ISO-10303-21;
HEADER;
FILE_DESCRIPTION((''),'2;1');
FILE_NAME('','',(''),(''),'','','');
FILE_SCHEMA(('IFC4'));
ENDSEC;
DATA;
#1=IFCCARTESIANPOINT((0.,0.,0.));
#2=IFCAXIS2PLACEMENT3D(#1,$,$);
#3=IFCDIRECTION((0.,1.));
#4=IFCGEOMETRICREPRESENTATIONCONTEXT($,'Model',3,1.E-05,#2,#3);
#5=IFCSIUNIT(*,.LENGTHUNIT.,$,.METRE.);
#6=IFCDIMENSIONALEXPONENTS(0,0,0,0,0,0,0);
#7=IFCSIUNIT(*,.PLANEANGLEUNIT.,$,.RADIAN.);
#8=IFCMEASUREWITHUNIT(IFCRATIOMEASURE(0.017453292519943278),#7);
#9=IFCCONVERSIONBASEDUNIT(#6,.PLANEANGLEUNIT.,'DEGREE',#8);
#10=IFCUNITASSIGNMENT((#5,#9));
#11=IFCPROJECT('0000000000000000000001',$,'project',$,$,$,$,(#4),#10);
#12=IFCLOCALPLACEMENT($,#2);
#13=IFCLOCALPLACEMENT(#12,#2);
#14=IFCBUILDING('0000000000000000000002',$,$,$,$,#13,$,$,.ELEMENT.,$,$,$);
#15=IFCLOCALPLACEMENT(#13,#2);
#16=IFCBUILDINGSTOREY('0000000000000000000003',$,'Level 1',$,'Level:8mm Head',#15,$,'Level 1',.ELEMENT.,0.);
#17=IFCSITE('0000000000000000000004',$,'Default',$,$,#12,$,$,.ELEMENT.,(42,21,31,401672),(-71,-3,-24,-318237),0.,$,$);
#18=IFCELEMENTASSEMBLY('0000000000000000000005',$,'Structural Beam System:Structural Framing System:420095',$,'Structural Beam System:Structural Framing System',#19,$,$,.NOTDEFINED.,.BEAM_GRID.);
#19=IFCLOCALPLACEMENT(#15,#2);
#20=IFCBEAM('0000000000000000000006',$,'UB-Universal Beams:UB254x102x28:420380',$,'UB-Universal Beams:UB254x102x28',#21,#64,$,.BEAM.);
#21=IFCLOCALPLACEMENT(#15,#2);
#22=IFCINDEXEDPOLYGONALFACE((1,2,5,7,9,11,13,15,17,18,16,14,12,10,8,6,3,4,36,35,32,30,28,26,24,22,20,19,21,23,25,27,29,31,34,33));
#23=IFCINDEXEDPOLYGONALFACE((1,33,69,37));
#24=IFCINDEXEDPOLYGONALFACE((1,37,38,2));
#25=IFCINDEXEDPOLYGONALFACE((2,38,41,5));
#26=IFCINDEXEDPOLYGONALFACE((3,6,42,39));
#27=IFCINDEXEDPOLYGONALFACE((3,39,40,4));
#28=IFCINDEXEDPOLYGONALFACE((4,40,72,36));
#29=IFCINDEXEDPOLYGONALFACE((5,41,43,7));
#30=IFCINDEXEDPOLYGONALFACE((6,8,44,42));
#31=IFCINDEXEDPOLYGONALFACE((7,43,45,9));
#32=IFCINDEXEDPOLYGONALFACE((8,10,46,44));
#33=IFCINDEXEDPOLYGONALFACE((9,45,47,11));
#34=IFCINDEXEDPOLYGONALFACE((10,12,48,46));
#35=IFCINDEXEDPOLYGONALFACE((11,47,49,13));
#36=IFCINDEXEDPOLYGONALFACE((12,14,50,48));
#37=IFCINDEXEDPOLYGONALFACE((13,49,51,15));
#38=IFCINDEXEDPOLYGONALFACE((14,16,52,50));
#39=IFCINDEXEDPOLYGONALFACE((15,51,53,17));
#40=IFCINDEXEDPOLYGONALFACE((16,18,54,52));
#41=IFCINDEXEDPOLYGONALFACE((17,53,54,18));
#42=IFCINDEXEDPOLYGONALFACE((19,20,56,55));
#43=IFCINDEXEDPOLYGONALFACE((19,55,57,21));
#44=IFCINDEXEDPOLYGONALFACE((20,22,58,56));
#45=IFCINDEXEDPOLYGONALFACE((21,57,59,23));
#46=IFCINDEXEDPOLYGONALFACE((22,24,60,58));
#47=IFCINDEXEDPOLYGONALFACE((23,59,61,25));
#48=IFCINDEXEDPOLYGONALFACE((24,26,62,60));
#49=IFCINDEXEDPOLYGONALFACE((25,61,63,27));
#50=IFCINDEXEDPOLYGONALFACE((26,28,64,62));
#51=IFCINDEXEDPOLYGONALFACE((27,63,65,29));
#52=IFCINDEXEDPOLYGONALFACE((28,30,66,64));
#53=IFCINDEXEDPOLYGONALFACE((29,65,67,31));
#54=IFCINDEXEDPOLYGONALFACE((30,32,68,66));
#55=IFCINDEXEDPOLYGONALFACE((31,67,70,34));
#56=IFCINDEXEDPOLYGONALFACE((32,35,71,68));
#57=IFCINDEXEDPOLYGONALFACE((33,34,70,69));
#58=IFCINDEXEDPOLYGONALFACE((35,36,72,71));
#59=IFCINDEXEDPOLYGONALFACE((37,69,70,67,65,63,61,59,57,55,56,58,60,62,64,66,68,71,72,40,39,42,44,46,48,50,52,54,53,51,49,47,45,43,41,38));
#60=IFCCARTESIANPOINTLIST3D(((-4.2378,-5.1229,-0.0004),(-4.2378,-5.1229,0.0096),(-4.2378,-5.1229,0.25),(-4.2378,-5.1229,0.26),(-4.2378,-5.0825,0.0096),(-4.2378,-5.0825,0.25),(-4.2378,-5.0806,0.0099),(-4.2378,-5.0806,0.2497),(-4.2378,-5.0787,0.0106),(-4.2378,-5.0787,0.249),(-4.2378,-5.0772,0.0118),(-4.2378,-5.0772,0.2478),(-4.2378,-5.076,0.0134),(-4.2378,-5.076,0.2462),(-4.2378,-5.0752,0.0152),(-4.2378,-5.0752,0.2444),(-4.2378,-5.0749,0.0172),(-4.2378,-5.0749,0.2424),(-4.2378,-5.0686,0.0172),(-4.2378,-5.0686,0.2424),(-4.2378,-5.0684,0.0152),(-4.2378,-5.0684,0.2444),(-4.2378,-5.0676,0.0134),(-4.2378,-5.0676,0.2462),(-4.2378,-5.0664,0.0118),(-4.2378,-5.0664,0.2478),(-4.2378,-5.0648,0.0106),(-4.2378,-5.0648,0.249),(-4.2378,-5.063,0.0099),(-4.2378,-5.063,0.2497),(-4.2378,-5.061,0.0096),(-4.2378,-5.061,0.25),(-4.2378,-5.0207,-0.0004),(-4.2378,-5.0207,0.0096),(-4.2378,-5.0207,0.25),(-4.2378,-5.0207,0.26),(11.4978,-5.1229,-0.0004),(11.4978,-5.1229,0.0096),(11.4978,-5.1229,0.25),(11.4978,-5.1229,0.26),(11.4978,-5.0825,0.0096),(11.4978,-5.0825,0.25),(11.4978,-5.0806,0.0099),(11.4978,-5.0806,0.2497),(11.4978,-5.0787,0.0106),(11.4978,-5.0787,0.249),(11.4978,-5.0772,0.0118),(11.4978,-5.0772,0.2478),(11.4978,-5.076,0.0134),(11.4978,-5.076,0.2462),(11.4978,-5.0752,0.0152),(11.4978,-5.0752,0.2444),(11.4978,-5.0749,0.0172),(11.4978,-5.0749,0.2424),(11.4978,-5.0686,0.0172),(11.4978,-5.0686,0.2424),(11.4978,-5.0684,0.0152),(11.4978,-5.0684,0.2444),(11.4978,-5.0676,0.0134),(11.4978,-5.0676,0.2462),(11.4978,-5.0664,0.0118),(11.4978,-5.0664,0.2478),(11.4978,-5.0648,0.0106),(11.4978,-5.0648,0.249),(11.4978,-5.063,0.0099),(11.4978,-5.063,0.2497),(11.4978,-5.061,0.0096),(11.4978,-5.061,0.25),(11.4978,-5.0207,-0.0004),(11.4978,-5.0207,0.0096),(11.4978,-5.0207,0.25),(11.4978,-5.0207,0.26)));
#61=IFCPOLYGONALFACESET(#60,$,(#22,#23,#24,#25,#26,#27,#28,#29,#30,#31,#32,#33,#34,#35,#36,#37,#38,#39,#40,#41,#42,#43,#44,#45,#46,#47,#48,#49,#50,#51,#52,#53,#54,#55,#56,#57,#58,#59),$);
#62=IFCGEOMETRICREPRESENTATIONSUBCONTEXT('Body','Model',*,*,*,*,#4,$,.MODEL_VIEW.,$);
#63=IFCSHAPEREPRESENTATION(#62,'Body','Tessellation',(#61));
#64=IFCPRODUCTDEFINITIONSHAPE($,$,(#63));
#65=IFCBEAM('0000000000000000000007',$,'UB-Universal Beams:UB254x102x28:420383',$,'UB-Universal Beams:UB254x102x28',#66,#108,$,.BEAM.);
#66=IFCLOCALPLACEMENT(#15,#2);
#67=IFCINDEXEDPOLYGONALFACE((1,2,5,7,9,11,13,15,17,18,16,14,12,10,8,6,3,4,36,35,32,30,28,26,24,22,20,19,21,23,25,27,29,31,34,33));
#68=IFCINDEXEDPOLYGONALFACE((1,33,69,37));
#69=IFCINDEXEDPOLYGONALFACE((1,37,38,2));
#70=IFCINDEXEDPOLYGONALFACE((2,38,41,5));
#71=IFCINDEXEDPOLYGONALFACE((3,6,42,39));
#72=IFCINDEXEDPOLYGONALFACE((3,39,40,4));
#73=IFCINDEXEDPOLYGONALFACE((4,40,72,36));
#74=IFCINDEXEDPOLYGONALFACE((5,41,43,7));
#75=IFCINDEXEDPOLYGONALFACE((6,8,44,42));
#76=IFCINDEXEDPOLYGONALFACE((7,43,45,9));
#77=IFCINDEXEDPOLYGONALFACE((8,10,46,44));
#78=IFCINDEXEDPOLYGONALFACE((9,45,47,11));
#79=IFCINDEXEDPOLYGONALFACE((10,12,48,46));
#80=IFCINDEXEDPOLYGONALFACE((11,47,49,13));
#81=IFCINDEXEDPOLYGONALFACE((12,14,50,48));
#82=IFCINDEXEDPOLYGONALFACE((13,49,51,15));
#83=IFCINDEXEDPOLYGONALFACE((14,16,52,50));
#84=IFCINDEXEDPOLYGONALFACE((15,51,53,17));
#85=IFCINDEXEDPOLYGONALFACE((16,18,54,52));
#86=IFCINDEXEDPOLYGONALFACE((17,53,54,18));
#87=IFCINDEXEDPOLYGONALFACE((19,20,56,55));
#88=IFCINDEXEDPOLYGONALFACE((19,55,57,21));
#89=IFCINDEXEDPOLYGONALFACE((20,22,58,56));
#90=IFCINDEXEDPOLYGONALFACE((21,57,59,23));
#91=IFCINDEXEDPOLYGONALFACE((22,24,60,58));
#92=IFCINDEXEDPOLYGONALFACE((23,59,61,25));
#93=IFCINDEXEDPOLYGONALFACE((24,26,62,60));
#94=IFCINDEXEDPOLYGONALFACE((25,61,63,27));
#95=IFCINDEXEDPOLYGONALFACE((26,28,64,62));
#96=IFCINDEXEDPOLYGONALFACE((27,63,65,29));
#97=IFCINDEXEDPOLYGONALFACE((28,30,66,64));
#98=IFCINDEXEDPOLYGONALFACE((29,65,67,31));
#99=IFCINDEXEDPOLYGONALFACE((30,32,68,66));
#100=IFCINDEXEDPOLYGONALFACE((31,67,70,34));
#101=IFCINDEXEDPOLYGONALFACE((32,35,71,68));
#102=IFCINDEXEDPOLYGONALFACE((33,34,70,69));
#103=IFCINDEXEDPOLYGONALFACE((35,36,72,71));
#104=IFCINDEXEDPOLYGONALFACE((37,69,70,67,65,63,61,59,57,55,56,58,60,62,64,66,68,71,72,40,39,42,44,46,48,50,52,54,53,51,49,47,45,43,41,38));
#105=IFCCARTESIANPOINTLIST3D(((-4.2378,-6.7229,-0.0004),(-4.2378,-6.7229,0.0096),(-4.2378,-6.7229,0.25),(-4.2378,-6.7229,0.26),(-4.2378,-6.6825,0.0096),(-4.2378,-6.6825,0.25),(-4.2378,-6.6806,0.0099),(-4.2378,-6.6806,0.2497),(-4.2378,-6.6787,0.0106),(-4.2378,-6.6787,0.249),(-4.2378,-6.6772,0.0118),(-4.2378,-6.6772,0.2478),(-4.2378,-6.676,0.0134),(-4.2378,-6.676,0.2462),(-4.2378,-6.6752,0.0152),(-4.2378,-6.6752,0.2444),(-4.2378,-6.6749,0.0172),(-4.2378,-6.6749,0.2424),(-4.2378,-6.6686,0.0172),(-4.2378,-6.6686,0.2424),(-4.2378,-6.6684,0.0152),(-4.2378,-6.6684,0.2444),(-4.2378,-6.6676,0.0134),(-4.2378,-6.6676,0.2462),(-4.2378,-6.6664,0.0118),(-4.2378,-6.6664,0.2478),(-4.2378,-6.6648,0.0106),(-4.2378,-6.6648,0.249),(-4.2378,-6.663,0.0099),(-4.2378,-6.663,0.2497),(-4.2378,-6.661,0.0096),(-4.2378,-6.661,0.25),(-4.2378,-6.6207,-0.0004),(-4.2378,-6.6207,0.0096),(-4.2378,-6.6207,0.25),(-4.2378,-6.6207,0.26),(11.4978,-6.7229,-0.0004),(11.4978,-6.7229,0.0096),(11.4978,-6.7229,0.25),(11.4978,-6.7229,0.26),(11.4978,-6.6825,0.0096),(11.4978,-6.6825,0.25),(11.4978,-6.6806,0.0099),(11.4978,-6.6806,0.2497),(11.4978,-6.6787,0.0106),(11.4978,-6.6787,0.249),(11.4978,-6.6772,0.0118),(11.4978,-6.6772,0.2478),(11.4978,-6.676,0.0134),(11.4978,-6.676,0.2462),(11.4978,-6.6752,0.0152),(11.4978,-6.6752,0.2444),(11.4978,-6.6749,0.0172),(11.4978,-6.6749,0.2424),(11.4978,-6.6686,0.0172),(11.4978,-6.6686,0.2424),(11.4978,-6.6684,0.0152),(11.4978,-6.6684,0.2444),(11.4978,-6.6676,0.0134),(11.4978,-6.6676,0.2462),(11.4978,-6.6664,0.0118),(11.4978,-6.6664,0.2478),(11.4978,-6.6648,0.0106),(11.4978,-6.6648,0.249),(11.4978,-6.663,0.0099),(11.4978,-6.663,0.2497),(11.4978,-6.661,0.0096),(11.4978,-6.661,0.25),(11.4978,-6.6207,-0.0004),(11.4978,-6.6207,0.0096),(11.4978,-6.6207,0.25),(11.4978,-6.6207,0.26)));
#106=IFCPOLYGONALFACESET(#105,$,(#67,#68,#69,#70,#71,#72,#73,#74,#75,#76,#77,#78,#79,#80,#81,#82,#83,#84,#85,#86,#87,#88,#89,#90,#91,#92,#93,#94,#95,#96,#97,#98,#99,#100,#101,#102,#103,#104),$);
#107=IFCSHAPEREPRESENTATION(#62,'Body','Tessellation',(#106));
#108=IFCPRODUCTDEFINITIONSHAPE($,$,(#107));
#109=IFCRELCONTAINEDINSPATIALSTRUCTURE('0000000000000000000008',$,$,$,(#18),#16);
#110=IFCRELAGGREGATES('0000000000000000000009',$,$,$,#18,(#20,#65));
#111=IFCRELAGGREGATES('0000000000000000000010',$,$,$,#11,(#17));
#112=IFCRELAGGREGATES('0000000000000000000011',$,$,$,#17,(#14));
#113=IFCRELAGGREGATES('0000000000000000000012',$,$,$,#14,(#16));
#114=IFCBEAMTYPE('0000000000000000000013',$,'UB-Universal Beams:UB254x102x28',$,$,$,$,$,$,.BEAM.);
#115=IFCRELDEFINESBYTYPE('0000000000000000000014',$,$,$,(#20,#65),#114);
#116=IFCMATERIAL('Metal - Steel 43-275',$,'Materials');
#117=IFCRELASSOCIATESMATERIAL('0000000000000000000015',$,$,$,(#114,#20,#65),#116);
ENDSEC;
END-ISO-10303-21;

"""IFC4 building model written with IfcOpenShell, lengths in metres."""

from ifc_helpers import new_model, entity, si_unit, converted_unit, direction, frame, origin, place, context, subcontext, project, spatial, line, arc, indexed_curve, outline, extrude, source, transform, mapped, material, type_object, type_shapes, element, aggregate, save


model = new_model("IFC4")

# Units and contexts
model_context = context("Model", 3, precision=1e-05, world=origin(), true_north=direction((0.0, 1.0)))
body_context = subcontext(model_context, "Body", "Model", "MODEL_VIEW")
ifc_project = project(units=[si_unit("LENGTHUNIT", "METRE"), converted_unit("PLANEANGLEUNIT", "DEGREE", entity("IfcRatioMeasure", 0.017453292519943278), si_unit("PLANEANGLEUNIT", "RADIAN"), dimensions=[0, 0, 0, 0, 0, 0, 0])], contexts=[model_context])

# Site, building, storey
site_placement = place(None, origin())
site = spatial("IfcSite", under=ifc_project, at=site_placement, Name="Default", CompositionType="ELEMENT", RefLatitude=(42, 21, 31, 401672), RefLongitude=(-71, -3, -24, -318237), RefElevation=0.0)
building_placement = place(site_placement, origin())
building = spatial("IfcBuilding", under=site, at=building_placement, CompositionType="ELEMENT")
storey_placement = place(building_placement, origin())
storey = spatial("IfcBuildingStorey", under=building, at=storey_placement, Name="Level 1", ObjectType="Level:8mm Head", LongName="Level 1", CompositionType="ELEMENT", Elevation=0.0)

# Shared definitions
ifc_material_1 = material(Name="Metal - Steel 43-275", Category="Materials")

# Element assembly, beams
assembly_placement = place(storey_placement, origin())
assembly = element("IfcElementAssembly", 1, at=assembly_placement, inside=storey, Name="Structural Beam System:Structural Framing System:420095", ObjectType="Structural Beam System:Structural Framing System", AssemblyPlace="NOTDEFINED", PredefinedType="BEAM_GRID")
beam_type_1 = type_object("IfcBeamType", Name="UB-Universal Beams:UB254x102x28", PredefinedType="BEAM", material=ifc_material_1)
shared_shape_1 = source(origin(), body_context, "Body", "SweptSolid", [
    extrude(outline(indexed_curve([(-0.1302, -0.0511), (-0.1202, -0.0511), (-0.1202, -0.0107), (-0.118, -0.0054), (-0.1126, -0.0031), (0.1126, -0.0031), (0.118, -0.0054), (0.1202, -0.0107), (0.1202, -0.0511), (0.1302, -0.0511), (0.1302, 0.0511), (0.1202, 0.0511), (0.1202, 0.0108), (0.118, 0.0054), (0.1126, 0.0032), (-0.1126, 0.0032), (-0.118, 0.0054), (-0.1202, 0.0108), (-0.1202, 0.0511), (-0.1302, 0.0511)], segments=[line(1, 2, 3), arc(3, 4, 5), line(5, 6), arc(6, 7, 8), line(8, 9, 10, 11, 12, 13), arc(13, 14, 15), line(15, 16), arc(16, 17, 18), line(18, 19, 20, 1)], self_intersect=False)), frame((-7.8373, 0.0, 0.0), z_axis=(1.0, 0.0, 0.0), x_axis=(0.0, 0.0, -1.0)), (0.0, 0.0, 1.0), 15.7356),
])
type_shapes(beam_type_1, [shared_shape_1])
beam_1_placement = place(assembly_placement, frame((3.5995, -5.0718, 0.1298)))
beam_1 = element("IfcBeam", 2, at=beam_1_placement, type_object=beam_type_1, material=ifc_material_1, Name="UB-Universal Beams:UB254x102x28:420380", ObjectType="UB-Universal Beams:UB254x102x28", PredefinedType="BEAM", context=body_context, shape_type="MappedRepresentation", body=[
    mapped(shared_shape_1, transform((0.0, 0.0, 0.0), scale=1.0)),
])
beam_2_placement = place(assembly_placement, frame((3.5995, -6.6718, 0.1298)))
beam_2 = element("IfcBeam", 3, at=beam_2_placement, type_object=beam_type_1, material=ifc_material_1, Name="UB-Universal Beams:UB254x102x28:420383", ObjectType="UB-Universal Beams:UB254x102x28", PredefinedType="BEAM", context=body_context, shape_type="MappedRepresentation", body=[
    mapped(shared_shape_1, transform((0.0, 0.0, 0.0), scale=1.0)),
])
aggregate(assembly, [beam_1, beam_2])

save(model, "model.ifc")
